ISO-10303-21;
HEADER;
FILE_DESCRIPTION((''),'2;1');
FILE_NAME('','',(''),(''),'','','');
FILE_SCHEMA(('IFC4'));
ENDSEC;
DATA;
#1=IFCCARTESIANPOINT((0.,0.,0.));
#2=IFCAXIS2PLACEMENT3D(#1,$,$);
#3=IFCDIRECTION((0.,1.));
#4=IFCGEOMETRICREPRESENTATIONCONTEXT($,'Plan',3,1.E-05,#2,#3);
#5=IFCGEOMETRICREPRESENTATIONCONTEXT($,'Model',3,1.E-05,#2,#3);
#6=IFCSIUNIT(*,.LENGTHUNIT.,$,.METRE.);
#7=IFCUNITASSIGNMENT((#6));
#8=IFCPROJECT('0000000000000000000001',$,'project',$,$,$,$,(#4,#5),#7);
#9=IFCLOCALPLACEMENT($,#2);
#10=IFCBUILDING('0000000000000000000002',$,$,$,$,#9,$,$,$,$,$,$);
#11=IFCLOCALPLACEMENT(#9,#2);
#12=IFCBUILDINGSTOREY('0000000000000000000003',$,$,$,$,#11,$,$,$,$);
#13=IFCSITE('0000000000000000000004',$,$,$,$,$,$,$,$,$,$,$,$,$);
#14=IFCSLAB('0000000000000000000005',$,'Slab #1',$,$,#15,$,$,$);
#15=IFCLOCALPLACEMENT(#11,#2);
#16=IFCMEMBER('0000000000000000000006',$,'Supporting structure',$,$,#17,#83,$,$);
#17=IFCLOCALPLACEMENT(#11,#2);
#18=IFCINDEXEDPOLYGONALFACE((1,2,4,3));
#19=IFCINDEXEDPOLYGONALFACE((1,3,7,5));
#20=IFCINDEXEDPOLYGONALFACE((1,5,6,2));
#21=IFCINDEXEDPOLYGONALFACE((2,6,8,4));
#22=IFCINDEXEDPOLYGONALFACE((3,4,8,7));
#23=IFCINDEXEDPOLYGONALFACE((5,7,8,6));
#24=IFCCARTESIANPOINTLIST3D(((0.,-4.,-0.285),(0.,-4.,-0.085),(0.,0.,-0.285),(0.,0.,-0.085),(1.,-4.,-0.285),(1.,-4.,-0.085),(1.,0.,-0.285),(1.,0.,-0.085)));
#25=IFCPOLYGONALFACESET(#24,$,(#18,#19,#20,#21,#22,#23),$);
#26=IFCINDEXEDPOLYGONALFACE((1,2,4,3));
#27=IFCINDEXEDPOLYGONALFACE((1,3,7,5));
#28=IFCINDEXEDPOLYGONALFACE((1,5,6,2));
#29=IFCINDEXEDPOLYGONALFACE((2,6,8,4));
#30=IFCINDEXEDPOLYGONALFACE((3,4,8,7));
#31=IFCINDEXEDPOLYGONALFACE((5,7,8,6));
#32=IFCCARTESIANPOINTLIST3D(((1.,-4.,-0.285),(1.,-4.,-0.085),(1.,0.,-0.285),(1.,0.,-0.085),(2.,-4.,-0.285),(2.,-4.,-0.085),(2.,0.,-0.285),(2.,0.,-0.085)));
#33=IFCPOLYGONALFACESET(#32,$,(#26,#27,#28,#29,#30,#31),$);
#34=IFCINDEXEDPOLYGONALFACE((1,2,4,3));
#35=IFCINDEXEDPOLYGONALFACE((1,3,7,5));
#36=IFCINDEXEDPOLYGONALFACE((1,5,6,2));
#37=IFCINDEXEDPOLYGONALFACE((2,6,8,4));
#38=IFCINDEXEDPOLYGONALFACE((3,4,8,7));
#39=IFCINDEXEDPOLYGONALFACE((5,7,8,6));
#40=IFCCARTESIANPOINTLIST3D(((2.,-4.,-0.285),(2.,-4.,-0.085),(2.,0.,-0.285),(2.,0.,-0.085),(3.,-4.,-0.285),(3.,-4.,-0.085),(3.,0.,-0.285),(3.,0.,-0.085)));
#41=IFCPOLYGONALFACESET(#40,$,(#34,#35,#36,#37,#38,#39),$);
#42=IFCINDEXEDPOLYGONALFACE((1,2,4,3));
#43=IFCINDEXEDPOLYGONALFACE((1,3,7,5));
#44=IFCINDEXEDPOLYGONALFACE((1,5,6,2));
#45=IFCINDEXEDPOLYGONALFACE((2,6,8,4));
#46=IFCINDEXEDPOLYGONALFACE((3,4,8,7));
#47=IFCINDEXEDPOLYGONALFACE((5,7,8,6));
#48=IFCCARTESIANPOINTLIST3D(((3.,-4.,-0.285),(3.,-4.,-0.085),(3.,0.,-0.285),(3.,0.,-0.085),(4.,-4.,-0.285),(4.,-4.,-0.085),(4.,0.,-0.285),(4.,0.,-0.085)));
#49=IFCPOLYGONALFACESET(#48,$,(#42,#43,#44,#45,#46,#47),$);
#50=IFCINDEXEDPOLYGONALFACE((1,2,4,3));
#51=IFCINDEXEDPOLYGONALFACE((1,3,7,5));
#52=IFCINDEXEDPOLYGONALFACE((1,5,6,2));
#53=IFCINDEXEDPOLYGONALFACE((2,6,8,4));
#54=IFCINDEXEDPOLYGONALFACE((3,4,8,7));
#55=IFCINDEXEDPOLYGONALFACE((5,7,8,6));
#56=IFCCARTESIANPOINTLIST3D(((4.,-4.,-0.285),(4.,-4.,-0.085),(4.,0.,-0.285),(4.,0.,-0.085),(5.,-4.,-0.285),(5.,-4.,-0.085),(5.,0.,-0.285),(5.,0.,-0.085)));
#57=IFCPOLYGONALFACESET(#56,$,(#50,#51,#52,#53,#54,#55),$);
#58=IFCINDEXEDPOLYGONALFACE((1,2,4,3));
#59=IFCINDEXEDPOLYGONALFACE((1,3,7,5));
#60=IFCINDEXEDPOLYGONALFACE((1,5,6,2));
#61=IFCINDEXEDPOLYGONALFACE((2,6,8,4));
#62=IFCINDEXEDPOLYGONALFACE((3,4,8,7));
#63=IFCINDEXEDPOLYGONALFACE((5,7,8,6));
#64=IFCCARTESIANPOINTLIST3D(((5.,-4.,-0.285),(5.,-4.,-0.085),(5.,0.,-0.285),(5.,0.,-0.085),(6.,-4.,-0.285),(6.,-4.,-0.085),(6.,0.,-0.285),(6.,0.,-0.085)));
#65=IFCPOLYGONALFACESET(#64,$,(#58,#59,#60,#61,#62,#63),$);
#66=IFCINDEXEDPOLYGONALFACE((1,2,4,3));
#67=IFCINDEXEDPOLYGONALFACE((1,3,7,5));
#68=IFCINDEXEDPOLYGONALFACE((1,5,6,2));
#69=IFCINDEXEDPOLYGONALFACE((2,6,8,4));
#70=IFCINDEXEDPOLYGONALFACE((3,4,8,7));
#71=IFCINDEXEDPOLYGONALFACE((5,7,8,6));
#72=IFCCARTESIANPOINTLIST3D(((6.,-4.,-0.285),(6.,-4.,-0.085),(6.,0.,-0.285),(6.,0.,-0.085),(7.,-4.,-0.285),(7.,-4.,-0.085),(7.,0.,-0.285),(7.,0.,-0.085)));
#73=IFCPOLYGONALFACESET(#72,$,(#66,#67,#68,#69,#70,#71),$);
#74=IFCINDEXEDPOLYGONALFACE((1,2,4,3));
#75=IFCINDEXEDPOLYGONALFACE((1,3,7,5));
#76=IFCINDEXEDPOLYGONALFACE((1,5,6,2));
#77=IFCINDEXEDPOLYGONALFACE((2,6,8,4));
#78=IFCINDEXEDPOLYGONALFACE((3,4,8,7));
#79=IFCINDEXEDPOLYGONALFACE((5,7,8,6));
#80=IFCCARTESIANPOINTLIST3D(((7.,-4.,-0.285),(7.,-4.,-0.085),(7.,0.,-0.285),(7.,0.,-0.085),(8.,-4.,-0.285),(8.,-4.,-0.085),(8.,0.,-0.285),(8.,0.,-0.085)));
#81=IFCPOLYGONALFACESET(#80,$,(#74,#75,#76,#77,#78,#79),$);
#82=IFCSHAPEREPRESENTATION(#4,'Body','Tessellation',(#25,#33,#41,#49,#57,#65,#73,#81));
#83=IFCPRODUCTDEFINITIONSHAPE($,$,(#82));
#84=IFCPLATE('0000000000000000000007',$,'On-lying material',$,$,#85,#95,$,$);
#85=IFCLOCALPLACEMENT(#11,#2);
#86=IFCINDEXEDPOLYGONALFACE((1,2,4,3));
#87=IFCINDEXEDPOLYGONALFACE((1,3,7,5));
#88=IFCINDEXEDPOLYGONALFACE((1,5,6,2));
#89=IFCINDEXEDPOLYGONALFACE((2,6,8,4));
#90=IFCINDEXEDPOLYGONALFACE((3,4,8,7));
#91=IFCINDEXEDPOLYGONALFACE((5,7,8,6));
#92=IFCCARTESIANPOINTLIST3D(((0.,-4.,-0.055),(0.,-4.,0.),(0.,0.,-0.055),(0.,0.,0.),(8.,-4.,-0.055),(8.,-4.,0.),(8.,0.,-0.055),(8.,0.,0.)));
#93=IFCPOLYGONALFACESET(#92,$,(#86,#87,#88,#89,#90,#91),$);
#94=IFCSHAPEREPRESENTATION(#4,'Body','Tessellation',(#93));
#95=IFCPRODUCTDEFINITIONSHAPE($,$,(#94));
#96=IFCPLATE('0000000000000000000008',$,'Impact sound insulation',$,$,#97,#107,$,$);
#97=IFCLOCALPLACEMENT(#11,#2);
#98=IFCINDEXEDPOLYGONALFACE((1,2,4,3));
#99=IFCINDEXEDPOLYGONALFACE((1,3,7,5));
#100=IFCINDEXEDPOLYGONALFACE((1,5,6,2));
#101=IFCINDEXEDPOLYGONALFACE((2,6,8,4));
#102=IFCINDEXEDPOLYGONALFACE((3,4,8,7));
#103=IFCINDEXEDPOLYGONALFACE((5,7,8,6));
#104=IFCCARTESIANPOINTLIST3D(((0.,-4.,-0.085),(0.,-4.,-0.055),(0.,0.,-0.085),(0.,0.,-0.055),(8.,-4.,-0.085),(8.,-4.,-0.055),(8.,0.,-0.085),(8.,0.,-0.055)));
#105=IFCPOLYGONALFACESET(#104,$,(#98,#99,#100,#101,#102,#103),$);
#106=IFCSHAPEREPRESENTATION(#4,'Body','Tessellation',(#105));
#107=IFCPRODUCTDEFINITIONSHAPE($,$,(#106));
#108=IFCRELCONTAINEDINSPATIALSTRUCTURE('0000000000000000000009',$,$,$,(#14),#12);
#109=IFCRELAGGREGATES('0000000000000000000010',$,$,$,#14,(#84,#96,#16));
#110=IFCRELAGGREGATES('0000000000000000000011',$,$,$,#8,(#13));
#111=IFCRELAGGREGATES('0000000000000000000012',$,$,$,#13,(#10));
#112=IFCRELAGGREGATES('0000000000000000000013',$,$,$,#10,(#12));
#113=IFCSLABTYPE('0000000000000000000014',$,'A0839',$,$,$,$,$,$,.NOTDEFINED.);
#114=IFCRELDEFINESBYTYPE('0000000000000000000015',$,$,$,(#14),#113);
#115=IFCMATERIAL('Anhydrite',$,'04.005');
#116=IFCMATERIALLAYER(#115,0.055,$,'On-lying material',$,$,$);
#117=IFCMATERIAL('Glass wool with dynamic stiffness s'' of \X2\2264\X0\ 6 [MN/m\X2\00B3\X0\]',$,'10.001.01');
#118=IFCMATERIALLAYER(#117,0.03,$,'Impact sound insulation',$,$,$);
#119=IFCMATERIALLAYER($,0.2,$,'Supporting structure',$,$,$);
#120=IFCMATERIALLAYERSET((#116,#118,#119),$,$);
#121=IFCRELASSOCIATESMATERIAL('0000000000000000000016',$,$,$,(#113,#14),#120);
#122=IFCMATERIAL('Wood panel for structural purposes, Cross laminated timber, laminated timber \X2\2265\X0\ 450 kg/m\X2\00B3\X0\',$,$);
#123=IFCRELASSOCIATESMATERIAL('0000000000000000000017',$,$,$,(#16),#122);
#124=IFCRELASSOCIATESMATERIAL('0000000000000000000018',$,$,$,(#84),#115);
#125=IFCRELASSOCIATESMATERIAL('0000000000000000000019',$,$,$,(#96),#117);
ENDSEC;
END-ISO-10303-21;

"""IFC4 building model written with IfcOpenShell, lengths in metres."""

from ifc_helpers import new_model, si_unit, direction, frame, frame_2d, origin, origin_with_axes, place, context, project, spatial, rectangle, extrude, material, layer, layer_set, type_object, element, aggregate, save


model = new_model("IFC4")

# Units and contexts
plan_context = context("Plan", 3, precision=1e-05, world=origin(), true_north=direction((0.0, 1.0)))
model_context = context("Model", 3, precision=1e-05, world=origin(), true_north=direction((0.0, 1.0)))
ifc_project = project(units=[si_unit("LENGTHUNIT", "METRE")], contexts=[plan_context, model_context])

# Site, building, storey
site = spatial("IfcSite", under=ifc_project)
building_placement = place(None, origin())
building = spatial("IfcBuilding", under=site, at=building_placement)
storey_placement = place(building_placement, origin())
storey = spatial("IfcBuildingStorey", under=building, at=storey_placement)

# Slab, member, plates
ifc_material_1 = material(Name="Anhydrite", Category="04.005")
ifc_layer_1 = layer(ifc_material_1, 0.055, Name="On-lying material")
ifc_material_2 = material(Name="Glass wool with dynamic stiffness s' of ≤ 6 [MN/m³]", Category="10.001.01")
ifc_layer_2 = layer(ifc_material_2, 0.03, Name="Impact sound insulation")
ifc_layer_3 = layer(None, 0.2, Name="Supporting structure")
ifc_layer_set = layer_set([ifc_layer_1, ifc_layer_2, ifc_layer_3])
slab_type = type_object("IfcSlabType", Name="A0839", PredefinedType="NOTDEFINED", material=ifc_layer_set)
slab_placement = place(None, frame((0.0, 0.0, 0.0), z_axis=(0.0, 0.0, -1.0), x_axis=(1.0, 0.0, 0.0)))
slab = element("IfcSlab", 1, at=slab_placement, inside=storey, type_object=slab_type, material=ifc_layer_set, Name="Slab #1")
ifc_material_3 = material(Name="Wood panel for structural purposes, Cross laminated timber, laminated timber ≥ 450 kg/m³")
member_placement = place(slab_placement, origin())
member = element("IfcMember", 2, at=member_placement, material=ifc_material_3, Name="Supporting structure", context=plan_context, shape_type="SweptSolid", body=[
    extrude(rectangle(XDim=1.0, YDim=0.2, at=frame_2d((0.5, 0.1), x_axis=(1.0, 0.0))), frame((0.0, 4.0, 0.085), z_axis=(0.0, -1.0, 0.0), x_axis=(1.0, 0.0, 0.0)), (0.0, 0.0, 1.0), 4.0),
    extrude(rectangle(XDim=1.0, YDim=0.2, at=frame_2d((0.5, 0.1), x_axis=(1.0, 0.0))), frame((1.0, 4.0, 0.085), z_axis=(0.0, -1.0, 0.0), x_axis=(1.0, 0.0, 0.0)), (0.0, 0.0, 1.0), 4.0),
    extrude(rectangle(XDim=1.0, YDim=0.2, at=frame_2d((0.5, 0.1), x_axis=(1.0, 0.0))), frame((2.0, 4.0, 0.085), z_axis=(0.0, -1.0, 0.0), x_axis=(1.0, 0.0, 0.0)), (0.0, 0.0, 1.0), 4.0),
    extrude(rectangle(XDim=1.0, YDim=0.2, at=frame_2d((0.5, 0.1), x_axis=(1.0, 0.0))), frame((3.0, 4.0, 0.085), z_axis=(0.0, -1.0, 0.0), x_axis=(1.0, 0.0, 0.0)), (0.0, 0.0, 1.0), 4.0),
    extrude(rectangle(XDim=1.0, YDim=0.2, at=frame_2d((0.5, 0.1), x_axis=(1.0, 0.0))), frame((4.0, 4.0, 0.085), z_axis=(0.0, -1.0, 0.0), x_axis=(1.0, 0.0, 0.0)), (0.0, 0.0, 1.0), 4.0),
    extrude(rectangle(XDim=1.0, YDim=0.2, at=frame_2d((0.5, 0.1), x_axis=(1.0, 0.0))), frame((5.0, 4.0, 0.085), z_axis=(0.0, -1.0, 0.0), x_axis=(1.0, 0.0, 0.0)), (0.0, 0.0, 1.0), 4.0),
    extrude(rectangle(XDim=1.0, YDim=0.2, at=frame_2d((0.5, 0.1), x_axis=(1.0, 0.0))), frame((6.0, 4.0, 0.085), z_axis=(0.0, -1.0, 0.0), x_axis=(1.0, 0.0, 0.0)), (0.0, 0.0, 1.0), 4.0),
    extrude(rectangle(XDim=1.0, YDim=0.2, at=frame_2d((0.5, 0.1), x_axis=(1.0, 0.0))), frame((7.0, 4.0, 0.085), z_axis=(0.0, -1.0, 0.0), x_axis=(1.0, 0.0, 0.0)), (0.0, 0.0, 1.0), 4.0),
])
plate_1_placement = place(slab_placement, origin())
plate_1 = element("IfcPlate", 3, at=plate_1_placement, material=ifc_material_1, Name="On-lying material", context=plan_context, shape_type="SweptSolid", body=[
    extrude(rectangle(XDim=8.0, YDim=4.0, at=frame_2d((4.0, 2.0), x_axis=(1.0, 0.0))), origin_with_axes(), (0.0, 0.0, 1.0), 0.055),
])
plate_2_placement = place(slab_placement, origin())
plate_2 = element("IfcPlate", 4, at=plate_2_placement, material=ifc_material_2, Name="Impact sound insulation", context=plan_context, shape_type="SweptSolid", body=[
    extrude(rectangle(XDim=8.0, YDim=4.0, at=frame_2d((4.0, 2.0), x_axis=(1.0, 0.0))), frame((0.0, 0.0, 0.055), z_axis=(0.0, 0.0, 1.0), x_axis=(1.0, 0.0, 0.0)), (0.0, 0.0, 1.0), 0.03),
])
aggregate(slab, [plate_1, plate_2, member])

save(model, "model.ifc")
